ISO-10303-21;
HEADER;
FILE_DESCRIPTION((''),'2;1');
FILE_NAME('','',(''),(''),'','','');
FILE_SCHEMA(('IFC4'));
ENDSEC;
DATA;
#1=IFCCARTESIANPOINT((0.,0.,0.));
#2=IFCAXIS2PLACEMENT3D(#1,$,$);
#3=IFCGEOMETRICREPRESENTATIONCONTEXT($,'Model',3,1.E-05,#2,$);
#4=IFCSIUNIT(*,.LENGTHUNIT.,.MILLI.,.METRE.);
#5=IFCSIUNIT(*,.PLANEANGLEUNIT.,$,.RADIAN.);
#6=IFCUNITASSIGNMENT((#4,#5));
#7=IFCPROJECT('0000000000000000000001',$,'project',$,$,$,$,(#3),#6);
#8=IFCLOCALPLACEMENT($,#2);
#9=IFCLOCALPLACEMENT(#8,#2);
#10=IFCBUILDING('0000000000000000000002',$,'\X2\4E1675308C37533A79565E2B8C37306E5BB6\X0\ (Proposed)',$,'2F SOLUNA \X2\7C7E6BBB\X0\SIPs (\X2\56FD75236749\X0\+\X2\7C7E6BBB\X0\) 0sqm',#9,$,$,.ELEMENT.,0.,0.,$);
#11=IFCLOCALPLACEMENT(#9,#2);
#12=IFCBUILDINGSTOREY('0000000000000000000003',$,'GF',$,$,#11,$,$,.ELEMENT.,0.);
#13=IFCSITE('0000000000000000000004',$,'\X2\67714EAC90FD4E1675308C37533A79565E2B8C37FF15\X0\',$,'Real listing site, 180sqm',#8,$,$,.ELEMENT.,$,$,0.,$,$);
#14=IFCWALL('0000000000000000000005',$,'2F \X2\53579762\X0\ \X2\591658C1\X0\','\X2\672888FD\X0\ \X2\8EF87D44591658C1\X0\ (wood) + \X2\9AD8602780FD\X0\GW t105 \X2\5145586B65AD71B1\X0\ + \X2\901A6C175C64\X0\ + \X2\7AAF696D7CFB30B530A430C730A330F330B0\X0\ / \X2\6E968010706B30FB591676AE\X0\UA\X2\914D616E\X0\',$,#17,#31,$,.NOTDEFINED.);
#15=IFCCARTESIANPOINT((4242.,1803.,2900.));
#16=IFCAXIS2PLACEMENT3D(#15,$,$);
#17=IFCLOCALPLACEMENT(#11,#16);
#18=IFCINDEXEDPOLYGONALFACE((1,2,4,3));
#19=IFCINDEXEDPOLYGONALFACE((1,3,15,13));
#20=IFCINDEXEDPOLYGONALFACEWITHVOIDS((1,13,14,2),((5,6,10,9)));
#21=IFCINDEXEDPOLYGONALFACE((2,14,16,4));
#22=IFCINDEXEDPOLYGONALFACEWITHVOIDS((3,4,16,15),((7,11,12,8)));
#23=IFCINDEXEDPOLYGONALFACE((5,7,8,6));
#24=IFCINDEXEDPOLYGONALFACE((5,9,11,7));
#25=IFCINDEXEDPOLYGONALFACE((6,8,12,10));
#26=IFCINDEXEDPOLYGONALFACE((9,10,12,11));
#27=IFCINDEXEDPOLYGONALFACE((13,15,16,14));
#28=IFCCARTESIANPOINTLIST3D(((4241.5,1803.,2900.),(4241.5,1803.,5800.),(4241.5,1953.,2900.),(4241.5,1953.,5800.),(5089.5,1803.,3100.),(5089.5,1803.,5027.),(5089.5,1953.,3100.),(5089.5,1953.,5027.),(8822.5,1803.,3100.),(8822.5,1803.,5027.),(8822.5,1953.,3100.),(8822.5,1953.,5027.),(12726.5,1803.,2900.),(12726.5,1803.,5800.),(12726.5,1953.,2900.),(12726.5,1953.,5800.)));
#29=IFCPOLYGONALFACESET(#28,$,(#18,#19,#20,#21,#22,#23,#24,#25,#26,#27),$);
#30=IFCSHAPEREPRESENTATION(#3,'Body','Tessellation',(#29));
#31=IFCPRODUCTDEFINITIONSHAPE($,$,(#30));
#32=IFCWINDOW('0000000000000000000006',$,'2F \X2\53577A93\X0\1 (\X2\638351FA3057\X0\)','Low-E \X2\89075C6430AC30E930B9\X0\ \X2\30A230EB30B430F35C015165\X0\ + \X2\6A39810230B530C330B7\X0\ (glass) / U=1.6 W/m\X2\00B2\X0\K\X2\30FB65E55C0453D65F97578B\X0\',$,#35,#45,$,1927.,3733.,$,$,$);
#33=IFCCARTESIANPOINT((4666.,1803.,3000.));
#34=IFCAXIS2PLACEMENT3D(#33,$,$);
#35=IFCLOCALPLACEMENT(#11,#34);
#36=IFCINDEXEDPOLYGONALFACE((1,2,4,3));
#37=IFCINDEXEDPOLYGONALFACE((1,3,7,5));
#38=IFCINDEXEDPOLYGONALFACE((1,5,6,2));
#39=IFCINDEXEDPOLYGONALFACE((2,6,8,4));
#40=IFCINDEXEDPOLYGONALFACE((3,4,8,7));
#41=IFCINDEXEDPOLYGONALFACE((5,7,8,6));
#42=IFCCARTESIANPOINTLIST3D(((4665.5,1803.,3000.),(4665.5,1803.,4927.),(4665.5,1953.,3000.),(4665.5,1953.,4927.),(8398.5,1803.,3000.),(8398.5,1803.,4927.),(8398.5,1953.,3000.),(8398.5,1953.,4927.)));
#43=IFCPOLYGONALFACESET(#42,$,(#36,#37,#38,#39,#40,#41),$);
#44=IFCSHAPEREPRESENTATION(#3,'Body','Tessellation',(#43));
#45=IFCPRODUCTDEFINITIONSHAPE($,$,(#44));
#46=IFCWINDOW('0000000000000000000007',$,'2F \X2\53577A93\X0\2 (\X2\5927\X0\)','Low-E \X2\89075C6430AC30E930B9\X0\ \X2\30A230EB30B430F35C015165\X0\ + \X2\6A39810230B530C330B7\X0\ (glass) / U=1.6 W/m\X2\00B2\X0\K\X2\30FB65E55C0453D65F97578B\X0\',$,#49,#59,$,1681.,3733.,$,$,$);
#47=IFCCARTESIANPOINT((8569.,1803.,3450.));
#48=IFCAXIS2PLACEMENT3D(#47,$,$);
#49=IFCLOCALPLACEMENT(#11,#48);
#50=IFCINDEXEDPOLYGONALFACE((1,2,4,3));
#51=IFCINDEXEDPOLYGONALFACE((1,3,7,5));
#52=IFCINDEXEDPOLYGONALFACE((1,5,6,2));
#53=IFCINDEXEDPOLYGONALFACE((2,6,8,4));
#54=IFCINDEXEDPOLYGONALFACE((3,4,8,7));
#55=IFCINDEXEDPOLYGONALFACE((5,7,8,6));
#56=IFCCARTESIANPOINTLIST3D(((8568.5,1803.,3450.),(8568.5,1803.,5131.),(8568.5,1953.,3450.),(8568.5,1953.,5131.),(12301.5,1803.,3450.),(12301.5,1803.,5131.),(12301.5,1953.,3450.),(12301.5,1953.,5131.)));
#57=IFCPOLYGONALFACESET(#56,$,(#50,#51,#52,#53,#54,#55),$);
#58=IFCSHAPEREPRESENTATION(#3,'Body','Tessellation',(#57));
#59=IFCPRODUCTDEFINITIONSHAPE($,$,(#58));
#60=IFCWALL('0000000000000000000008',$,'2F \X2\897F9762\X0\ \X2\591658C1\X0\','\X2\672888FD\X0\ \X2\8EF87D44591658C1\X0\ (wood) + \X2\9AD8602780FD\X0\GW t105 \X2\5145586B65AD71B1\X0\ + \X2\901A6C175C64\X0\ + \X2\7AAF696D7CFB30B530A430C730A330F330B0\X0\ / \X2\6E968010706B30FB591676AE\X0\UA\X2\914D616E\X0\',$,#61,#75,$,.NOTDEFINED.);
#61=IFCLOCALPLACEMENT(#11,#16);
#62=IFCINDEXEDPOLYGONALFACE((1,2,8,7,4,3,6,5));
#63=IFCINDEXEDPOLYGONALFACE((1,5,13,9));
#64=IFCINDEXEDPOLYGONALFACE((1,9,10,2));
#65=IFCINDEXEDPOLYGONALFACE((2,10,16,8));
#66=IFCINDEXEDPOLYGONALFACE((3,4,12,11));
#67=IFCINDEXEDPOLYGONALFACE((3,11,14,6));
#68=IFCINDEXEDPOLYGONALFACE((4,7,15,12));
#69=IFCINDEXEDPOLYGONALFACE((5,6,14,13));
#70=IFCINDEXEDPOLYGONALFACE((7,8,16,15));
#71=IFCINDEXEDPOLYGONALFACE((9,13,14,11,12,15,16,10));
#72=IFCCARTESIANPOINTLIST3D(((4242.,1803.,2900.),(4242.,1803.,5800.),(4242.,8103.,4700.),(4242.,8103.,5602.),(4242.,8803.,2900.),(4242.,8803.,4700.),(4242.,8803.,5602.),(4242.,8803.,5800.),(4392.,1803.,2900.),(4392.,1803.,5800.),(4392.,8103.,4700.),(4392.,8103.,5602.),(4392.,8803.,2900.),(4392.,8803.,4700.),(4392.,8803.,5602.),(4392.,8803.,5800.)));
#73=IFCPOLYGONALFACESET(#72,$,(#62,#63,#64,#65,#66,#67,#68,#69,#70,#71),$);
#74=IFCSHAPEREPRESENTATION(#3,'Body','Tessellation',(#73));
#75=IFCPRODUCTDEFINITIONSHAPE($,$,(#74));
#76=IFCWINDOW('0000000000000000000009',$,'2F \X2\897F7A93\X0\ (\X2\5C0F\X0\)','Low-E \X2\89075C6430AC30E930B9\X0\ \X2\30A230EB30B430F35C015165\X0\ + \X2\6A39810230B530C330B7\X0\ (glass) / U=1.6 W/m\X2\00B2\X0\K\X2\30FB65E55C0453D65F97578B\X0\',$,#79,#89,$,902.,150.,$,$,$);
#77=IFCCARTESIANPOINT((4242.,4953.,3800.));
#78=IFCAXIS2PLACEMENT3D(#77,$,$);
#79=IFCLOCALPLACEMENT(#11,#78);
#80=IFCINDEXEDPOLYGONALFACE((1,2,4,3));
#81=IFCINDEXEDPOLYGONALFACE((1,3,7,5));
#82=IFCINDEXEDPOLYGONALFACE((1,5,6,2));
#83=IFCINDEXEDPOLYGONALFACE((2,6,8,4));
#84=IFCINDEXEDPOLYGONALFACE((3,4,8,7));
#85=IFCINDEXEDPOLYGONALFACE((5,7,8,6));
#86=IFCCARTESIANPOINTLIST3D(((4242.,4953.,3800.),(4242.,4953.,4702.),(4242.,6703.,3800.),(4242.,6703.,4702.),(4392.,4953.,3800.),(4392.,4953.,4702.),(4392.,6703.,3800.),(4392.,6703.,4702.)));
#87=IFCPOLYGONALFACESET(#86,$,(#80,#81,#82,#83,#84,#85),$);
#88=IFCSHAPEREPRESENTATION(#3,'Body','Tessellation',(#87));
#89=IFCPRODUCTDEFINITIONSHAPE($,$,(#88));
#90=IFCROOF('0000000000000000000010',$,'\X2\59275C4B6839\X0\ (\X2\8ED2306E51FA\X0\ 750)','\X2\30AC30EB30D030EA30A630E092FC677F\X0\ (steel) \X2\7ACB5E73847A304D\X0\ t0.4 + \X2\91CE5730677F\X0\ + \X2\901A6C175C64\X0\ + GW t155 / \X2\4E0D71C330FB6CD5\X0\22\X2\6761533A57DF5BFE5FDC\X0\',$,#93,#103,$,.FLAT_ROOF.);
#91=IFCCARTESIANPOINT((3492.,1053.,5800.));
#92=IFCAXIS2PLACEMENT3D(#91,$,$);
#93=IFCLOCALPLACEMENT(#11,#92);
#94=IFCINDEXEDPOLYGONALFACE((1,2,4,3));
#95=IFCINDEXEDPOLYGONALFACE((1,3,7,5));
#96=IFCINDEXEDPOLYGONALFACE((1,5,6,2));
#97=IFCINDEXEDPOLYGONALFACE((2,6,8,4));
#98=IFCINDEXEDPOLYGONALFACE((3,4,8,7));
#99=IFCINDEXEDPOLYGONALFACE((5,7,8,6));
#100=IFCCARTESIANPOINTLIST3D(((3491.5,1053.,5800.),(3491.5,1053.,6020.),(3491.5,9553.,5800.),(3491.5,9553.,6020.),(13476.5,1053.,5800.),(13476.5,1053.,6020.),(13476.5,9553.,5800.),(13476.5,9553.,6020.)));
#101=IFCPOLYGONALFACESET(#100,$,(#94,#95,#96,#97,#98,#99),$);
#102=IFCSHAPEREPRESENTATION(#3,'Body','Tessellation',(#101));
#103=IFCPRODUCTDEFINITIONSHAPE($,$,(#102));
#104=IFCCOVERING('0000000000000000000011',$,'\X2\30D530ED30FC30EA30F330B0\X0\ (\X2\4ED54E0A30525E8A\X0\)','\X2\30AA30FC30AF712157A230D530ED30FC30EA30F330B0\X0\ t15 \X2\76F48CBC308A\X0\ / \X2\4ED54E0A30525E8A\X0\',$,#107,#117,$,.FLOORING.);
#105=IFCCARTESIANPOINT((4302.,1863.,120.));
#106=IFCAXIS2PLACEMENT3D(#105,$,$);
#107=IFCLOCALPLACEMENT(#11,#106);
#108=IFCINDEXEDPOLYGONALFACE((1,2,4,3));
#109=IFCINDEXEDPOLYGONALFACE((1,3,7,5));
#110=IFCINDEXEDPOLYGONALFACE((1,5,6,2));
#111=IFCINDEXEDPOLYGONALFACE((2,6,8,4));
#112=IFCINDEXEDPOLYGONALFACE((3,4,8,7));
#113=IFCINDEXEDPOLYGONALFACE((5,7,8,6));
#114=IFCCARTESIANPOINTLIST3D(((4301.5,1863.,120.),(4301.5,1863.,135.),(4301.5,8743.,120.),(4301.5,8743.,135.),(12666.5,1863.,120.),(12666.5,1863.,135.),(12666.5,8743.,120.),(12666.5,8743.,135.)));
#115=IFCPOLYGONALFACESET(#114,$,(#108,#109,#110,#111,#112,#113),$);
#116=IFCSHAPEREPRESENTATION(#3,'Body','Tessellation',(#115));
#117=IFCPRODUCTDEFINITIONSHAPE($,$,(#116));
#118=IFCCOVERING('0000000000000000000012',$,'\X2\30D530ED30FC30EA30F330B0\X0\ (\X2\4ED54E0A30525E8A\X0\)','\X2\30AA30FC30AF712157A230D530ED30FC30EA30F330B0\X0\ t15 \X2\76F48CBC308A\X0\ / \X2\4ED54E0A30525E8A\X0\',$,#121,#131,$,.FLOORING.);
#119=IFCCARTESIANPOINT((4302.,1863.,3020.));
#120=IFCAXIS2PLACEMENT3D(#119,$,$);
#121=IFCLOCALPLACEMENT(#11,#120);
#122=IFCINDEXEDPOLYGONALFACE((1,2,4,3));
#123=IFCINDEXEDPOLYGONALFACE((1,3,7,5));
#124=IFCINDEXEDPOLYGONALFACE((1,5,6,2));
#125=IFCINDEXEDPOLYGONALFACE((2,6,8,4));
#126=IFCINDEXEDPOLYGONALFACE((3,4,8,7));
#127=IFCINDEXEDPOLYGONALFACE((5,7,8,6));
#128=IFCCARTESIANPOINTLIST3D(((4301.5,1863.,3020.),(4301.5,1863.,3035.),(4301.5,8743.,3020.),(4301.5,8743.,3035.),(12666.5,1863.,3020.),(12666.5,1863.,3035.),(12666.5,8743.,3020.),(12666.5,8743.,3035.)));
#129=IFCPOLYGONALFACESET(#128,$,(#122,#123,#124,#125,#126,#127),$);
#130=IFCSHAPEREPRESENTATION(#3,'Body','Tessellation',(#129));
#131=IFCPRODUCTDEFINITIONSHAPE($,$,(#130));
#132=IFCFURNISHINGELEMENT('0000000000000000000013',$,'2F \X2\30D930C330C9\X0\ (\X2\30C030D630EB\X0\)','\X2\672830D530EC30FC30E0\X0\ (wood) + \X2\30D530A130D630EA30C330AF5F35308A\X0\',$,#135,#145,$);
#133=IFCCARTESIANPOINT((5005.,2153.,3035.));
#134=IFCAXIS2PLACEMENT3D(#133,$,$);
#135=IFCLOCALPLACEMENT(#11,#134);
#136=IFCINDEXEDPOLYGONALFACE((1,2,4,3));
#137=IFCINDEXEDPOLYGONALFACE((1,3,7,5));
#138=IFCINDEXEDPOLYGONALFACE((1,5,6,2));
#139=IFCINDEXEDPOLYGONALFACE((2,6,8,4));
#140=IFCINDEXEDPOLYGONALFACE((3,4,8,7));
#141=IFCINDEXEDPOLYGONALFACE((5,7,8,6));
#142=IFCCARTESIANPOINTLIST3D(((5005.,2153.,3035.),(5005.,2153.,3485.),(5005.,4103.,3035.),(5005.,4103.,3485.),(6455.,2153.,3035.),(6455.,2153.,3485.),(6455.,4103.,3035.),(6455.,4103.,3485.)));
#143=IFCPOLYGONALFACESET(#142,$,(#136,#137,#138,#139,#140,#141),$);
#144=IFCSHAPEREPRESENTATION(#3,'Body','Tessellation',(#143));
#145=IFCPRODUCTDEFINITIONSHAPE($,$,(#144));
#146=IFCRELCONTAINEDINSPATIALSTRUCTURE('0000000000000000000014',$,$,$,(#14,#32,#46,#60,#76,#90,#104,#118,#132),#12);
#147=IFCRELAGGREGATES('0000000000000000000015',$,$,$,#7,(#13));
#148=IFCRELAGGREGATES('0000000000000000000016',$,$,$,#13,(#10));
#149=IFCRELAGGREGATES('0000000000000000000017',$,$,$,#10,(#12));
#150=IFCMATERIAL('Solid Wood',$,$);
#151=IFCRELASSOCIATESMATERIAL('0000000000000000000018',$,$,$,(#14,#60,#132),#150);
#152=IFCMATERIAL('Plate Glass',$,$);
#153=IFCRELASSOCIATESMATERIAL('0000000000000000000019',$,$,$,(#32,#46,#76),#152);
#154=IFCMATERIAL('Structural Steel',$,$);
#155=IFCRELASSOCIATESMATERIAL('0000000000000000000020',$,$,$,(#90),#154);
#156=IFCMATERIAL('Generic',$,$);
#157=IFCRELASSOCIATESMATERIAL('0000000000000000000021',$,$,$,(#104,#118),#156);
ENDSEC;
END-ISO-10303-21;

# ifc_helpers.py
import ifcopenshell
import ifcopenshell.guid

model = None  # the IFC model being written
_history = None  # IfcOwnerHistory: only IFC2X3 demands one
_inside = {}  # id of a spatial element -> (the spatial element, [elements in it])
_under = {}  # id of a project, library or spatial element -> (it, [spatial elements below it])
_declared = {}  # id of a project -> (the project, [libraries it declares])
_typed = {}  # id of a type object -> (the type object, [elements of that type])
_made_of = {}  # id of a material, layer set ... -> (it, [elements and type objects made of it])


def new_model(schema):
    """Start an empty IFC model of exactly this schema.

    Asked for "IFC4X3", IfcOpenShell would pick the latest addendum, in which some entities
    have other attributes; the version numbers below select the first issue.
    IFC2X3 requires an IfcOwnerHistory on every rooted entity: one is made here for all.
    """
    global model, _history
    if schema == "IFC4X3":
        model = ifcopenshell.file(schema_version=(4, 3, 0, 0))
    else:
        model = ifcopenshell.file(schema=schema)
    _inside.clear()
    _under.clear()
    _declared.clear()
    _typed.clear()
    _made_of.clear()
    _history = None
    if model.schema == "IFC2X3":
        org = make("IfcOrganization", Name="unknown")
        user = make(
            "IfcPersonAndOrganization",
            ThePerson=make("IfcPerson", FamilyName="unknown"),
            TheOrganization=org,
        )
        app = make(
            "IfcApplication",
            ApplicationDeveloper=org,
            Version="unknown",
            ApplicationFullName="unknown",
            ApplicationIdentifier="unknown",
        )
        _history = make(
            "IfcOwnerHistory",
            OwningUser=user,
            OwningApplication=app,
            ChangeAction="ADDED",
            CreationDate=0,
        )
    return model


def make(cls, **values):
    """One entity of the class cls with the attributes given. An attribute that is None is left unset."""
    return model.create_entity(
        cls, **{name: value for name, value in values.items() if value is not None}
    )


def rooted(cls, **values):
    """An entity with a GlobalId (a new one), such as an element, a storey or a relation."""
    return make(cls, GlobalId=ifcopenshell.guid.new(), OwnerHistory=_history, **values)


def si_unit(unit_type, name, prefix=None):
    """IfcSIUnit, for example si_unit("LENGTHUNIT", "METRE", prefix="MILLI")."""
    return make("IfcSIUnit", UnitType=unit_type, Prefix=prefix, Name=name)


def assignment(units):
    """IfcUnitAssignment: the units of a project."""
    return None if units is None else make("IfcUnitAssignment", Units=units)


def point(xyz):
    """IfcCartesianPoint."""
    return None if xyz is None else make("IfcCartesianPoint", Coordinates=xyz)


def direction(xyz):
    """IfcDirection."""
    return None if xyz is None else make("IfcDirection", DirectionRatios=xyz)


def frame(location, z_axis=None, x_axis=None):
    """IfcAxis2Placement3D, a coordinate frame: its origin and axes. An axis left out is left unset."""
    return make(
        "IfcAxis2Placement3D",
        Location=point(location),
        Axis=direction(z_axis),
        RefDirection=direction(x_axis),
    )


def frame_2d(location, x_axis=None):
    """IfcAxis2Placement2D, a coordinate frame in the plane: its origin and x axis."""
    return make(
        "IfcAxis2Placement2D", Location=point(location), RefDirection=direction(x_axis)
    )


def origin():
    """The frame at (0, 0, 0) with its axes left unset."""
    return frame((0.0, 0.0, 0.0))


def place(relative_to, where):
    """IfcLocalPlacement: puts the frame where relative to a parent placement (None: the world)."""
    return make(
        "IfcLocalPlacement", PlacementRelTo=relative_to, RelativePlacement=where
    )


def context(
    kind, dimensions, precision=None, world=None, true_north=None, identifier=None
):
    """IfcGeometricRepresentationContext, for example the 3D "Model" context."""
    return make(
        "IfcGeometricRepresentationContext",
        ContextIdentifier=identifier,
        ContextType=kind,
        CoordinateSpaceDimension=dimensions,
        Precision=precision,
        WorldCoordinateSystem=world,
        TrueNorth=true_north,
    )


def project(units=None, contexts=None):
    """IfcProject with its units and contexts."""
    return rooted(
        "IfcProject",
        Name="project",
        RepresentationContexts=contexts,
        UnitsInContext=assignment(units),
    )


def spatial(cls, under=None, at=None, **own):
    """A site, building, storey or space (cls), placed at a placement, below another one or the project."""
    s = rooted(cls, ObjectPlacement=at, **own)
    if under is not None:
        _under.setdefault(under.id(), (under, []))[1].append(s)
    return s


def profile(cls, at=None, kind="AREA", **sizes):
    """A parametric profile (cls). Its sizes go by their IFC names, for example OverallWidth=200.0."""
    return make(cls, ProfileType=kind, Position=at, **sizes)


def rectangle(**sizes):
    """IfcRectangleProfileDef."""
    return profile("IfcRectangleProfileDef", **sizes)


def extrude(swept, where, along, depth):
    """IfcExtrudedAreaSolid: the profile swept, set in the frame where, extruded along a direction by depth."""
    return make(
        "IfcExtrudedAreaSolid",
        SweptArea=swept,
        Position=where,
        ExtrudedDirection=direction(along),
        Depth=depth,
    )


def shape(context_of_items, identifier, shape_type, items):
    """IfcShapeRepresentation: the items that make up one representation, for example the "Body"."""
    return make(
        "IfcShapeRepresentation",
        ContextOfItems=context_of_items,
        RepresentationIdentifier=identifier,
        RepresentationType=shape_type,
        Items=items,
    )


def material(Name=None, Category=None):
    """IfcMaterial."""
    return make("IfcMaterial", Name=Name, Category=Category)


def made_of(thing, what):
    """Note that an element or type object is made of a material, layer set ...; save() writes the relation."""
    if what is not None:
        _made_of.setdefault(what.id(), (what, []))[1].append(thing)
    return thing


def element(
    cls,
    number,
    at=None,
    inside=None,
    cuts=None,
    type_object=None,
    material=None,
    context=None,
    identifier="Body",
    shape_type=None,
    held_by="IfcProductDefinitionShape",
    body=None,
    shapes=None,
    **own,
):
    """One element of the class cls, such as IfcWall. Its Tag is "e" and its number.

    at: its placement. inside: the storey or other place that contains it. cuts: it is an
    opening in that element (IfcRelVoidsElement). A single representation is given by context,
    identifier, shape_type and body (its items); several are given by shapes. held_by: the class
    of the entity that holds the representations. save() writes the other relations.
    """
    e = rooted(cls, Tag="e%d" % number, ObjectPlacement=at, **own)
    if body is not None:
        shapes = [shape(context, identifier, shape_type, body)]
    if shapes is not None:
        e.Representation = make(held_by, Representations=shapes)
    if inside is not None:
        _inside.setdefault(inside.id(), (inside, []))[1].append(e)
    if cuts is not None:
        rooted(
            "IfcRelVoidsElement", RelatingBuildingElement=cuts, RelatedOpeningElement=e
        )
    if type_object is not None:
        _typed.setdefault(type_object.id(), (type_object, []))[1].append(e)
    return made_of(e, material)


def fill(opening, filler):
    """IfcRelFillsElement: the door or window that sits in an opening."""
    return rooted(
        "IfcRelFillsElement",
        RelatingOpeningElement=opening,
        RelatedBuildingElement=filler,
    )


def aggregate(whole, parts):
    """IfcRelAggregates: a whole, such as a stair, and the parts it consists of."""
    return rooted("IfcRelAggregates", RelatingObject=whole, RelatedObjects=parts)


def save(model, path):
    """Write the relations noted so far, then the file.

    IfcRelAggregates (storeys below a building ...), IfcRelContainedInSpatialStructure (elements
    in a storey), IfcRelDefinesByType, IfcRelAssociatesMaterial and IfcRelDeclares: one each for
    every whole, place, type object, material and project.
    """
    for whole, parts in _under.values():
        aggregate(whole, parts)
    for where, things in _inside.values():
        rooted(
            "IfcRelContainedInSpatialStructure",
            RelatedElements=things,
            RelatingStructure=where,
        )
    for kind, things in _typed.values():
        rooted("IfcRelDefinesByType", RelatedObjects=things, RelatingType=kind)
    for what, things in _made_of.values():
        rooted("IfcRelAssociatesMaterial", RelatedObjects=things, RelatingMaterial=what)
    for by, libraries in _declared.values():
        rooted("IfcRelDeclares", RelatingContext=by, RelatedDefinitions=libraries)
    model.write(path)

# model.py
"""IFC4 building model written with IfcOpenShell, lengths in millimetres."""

from ifc_helpers import new_model, si_unit, frame, frame_2d, origin, place, context, project, spatial, rectangle, extrude, material, element, fill, save


model = new_model("IFC4")

# Units and contexts
model_context = context("Model", 3, precision=1e-05, world=origin())
ifc_project = project(units=[si_unit("LENGTHUNIT", "METRE", prefix="MILLI"), si_unit("PLANEANGLEUNIT", "RADIAN")], contexts=[model_context])

# Site, building, storey
site_placement = place(None, origin())
site = spatial("IfcSite", under=ifc_project, at=site_placement, Name="東京都世田谷区祖師谷５", ObjectType="Real listing site, 180sqm", CompositionType="ELEMENT", RefElevation=0.0)
building_placement = place(site_placement, origin())
building = spatial("IfcBuilding", under=site, at=building_placement, Name="世田谷区祖師谷の家 (Proposed)", ObjectType="2F SOLUNA 籾殻SIPs (国産杉+籾殻) 0sqm", CompositionType="ELEMENT", ElevationOfRefHeight=0.0, ElevationOfTerrain=0.0)
storey_placement = place(building_placement, origin())
storey = spatial("IfcBuildingStorey", under=building, at=storey_placement, Name="GF", CompositionType="ELEMENT", Elevation=0.0)

# Shared definitions
ifc_material_1 = material(Name="Solid Wood")

# Shared definitions
ifc_material_2 = material(Name="Plate Glass")

# Wall, openings, windows
wall_1_placement = place(storey_placement, frame((4242.0, 1803.0, 2900.0)))
wall_1 = element("IfcWall", 1, at=wall_1_placement, inside=storey, material=ifc_material_1, Name="2F 南面 外壁", Description="木製 軸組外壁 (wood) + 高性能GW t105 充填断熱 + 通気層 + 窯業系サイディング / 準耐火・外皮UA配慮", PredefinedType="NOTDEFINED", context=model_context, shape_type="SweptSolid", body=[
    extrude(rectangle(XDim=8485.0, YDim=150.0, at=frame_2d((4242.0, 75.0))), frame((4242.0, 1803.0, 2900.0)), (0.0, 0.0, 1.0), 2900.0),
])
opening_1_placement = place(storey_placement, frame((4666.0, 1803.0, 3000.0)))
opening_1 = element("IfcOpeningElement", 2, at=opening_1_placement, cuts=wall_1, PredefinedType="NOTDEFINED", context=model_context, shape_type="SweptSolid", body=[
    extrude(rectangle(XDim=3733.0, YDim=150.0, at=frame_2d((1866.0, 75.0))), frame((4666.0, 1803.0, 3000.0)), (0.0, 0.0, 1.0), 1927.0),
])
opening_2_placement = place(storey_placement, frame((8569.0, 1803.0, 3450.0)))
opening_2 = element("IfcOpeningElement", 3, at=opening_2_placement, cuts=wall_1, PredefinedType="NOTDEFINED", context=model_context, shape_type="SweptSolid", body=[
    extrude(rectangle(XDim=3733.0, YDim=150.0, at=frame_2d((1866.0, 75.0))), frame((8569.0, 1803.0, 3450.0)), (0.0, 0.0, 1.0), 1681.0),
])
window_1_placement = place(storey_placement, frame((4666.0, 1803.0, 3000.0)))
window_1 = element("IfcWindow", 4, at=window_1_placement, inside=storey, material=ifc_material_2, Name="2F 南窓1 (掃出し)", Description="Low-E 複層ガラス アルゴン封入 + 樹脂サッシ (glass) / U=1.6 W/m²K・日射取得型", OverallHeight=1927.0, OverallWidth=3733.0, context=model_context, shape_type="SweptSolid", body=[
    extrude(rectangle(XDim=3733.0, YDim=150.0, at=frame_2d((1866.0, 75.0))), frame((4666.0, 1803.0, 3000.0)), (0.0, 0.0, 1.0), 1927.0),
])
fill(opening_1, window_1)
window_2_placement = place(storey_placement, frame((8569.0, 1803.0, 3450.0)))
window_2 = element("IfcWindow", 5, at=window_2_placement, inside=storey, material=ifc_material_2, Name="2F 南窓2 (大)", Description="Low-E 複層ガラス アルゴン封入 + 樹脂サッシ (glass) / U=1.6 W/m²K・日射取得型", OverallHeight=1681.0, OverallWidth=3733.0, context=model_context, shape_type="SweptSolid", body=[
    extrude(rectangle(XDim=3733.0, YDim=150.0, at=frame_2d((1866.0, 75.0))), frame((8569.0, 1803.0, 3450.0)), (0.0, 0.0, 1.0), 1681.0),
])
fill(opening_2, window_2)

# Wall, opening, window
wall_2_placement = place(storey_placement, frame((4242.0, 1803.0, 2900.0)))
wall_2 = element("IfcWall", 6, at=wall_2_placement, inside=storey, material=ifc_material_1, Name="2F 西面 外壁", Description="木製 軸組外壁 (wood) + 高性能GW t105 充填断熱 + 通気層 + 窯業系サイディング / 準耐火・外皮UA配慮", PredefinedType="NOTDEFINED", context=model_context, shape_type="SweptSolid", body=[
    extrude(rectangle(XDim=150.0, YDim=7000.0, at=frame_2d((75.0, 3500.0))), frame((4242.0, 1803.0, 2900.0)), (0.0, 0.0, 1.0), 2900.0),
])
opening_3_placement = place(storey_placement, frame((4242.0, 4953.0, 3800.0)))
opening_3 = element("IfcOpeningElement", 7, at=opening_3_placement, cuts=wall_2, PredefinedType="NOTDEFINED", context=model_context, shape_type="SweptSolid", body=[
    extrude(rectangle(XDim=150.0, YDim=1750.0, at=frame_2d((75.0, 875.0))), frame((4242.0, 4953.0, 3800.0)), (0.0, 0.0, 1.0), 902.0),
])
window_3_placement = place(storey_placement, frame((4242.0, 4953.0, 3800.0)))
window_3 = element("IfcWindow", 8, at=window_3_placement, inside=storey, material=ifc_material_2, Name="2F 西窓 (小)", Description="Low-E 複層ガラス アルゴン封入 + 樹脂サッシ (glass) / U=1.6 W/m²K・日射取得型", OverallHeight=902.0, OverallWidth=150.0, context=model_context, shape_type="SweptSolid", body=[
    extrude(rectangle(XDim=150.0, YDim=1750.0, at=frame_2d((75.0, 875.0))), frame((4242.0, 4953.0, 3800.0)), (0.0, 0.0, 1.0), 902.0),
])
fill(opening_3, window_3)

# Roof
ifc_material_3 = material(Name="Structural Steel")
roof_placement = place(storey_placement, frame((3492.0, 1053.0, 5800.0)))
element("IfcRoof", 9, at=roof_placement, inside=storey, material=ifc_material_3, Name="大屋根 (軒の出 750)", Description="ガルバリウム鋼板 (steel) 立平葺き t0.4 + 野地板 + 通気層 + GW t155 / 不燃・法22条区域対応", PredefinedType="FLAT_ROOF", context=model_context, shape_type="SweptSolid", body=[
    extrude(rectangle(XDim=9985.0, YDim=8500.0, at=frame_2d((4992.0, 4250.0))), frame((3492.0, 1053.0, 5800.0)), (0.0, 0.0, 1.0), 220.0),
])

# Coverings
ifc_material_4 = material(Name="Generic")
covering_1_placement = place(storey_placement, frame((4302.0, 1863.0, 120.0)))
element("IfcCovering", 10, at=covering_1_placement, inside=storey, material=ifc_material_4, Name="フローリング (仕上げ床)", Description="オーク無垢フローリング t15 直貼り / 仕上げ床", PredefinedType="FLOORING", context=model_context, shape_type="SweptSolid", body=[
    extrude(rectangle(XDim=8365.0, YDim=6880.0, at=frame_2d((4182.0, 3440.0))), frame((4302.0, 1863.0, 120.0)), (0.0, 0.0, 1.0), 15.0),
])
covering_2_placement = place(storey_placement, frame((4302.0, 1863.0, 3020.0)))
element("IfcCovering", 11, at=covering_2_placement, inside=storey, material=ifc_material_4, Name="フローリング (仕上げ床)", Description="オーク無垢フローリング t15 直貼り / 仕上げ床", PredefinedType="FLOORING", context=model_context, shape_type="SweptSolid", body=[
    extrude(rectangle(XDim=8365.0, YDim=6880.0, at=frame_2d((4182.0, 3440.0))), frame((4302.0, 1863.0, 3020.0)), (0.0, 0.0, 1.0), 15.0),
])

# Furnishing element
furnishing_placement = place(storey_placement, frame((5005.0, 2153.0, 3035.0)))
element("IfcFurnishingElement", 12, at=furnishing_placement, inside=storey, material=ifc_material_1, Name="2F ベッド (ダブル)", Description="木フレーム (wood) + ファブリック張り", context=model_context, shape_type="SweptSolid", body=[
    extrude(rectangle(XDim=1450.0, YDim=1950.0, at=frame_2d((725.0, 975.0))), frame((5005.0, 2153.0, 3035.0)), (0.0, 0.0, 1.0), 450.0),
])

save(model, "model.ifc")
